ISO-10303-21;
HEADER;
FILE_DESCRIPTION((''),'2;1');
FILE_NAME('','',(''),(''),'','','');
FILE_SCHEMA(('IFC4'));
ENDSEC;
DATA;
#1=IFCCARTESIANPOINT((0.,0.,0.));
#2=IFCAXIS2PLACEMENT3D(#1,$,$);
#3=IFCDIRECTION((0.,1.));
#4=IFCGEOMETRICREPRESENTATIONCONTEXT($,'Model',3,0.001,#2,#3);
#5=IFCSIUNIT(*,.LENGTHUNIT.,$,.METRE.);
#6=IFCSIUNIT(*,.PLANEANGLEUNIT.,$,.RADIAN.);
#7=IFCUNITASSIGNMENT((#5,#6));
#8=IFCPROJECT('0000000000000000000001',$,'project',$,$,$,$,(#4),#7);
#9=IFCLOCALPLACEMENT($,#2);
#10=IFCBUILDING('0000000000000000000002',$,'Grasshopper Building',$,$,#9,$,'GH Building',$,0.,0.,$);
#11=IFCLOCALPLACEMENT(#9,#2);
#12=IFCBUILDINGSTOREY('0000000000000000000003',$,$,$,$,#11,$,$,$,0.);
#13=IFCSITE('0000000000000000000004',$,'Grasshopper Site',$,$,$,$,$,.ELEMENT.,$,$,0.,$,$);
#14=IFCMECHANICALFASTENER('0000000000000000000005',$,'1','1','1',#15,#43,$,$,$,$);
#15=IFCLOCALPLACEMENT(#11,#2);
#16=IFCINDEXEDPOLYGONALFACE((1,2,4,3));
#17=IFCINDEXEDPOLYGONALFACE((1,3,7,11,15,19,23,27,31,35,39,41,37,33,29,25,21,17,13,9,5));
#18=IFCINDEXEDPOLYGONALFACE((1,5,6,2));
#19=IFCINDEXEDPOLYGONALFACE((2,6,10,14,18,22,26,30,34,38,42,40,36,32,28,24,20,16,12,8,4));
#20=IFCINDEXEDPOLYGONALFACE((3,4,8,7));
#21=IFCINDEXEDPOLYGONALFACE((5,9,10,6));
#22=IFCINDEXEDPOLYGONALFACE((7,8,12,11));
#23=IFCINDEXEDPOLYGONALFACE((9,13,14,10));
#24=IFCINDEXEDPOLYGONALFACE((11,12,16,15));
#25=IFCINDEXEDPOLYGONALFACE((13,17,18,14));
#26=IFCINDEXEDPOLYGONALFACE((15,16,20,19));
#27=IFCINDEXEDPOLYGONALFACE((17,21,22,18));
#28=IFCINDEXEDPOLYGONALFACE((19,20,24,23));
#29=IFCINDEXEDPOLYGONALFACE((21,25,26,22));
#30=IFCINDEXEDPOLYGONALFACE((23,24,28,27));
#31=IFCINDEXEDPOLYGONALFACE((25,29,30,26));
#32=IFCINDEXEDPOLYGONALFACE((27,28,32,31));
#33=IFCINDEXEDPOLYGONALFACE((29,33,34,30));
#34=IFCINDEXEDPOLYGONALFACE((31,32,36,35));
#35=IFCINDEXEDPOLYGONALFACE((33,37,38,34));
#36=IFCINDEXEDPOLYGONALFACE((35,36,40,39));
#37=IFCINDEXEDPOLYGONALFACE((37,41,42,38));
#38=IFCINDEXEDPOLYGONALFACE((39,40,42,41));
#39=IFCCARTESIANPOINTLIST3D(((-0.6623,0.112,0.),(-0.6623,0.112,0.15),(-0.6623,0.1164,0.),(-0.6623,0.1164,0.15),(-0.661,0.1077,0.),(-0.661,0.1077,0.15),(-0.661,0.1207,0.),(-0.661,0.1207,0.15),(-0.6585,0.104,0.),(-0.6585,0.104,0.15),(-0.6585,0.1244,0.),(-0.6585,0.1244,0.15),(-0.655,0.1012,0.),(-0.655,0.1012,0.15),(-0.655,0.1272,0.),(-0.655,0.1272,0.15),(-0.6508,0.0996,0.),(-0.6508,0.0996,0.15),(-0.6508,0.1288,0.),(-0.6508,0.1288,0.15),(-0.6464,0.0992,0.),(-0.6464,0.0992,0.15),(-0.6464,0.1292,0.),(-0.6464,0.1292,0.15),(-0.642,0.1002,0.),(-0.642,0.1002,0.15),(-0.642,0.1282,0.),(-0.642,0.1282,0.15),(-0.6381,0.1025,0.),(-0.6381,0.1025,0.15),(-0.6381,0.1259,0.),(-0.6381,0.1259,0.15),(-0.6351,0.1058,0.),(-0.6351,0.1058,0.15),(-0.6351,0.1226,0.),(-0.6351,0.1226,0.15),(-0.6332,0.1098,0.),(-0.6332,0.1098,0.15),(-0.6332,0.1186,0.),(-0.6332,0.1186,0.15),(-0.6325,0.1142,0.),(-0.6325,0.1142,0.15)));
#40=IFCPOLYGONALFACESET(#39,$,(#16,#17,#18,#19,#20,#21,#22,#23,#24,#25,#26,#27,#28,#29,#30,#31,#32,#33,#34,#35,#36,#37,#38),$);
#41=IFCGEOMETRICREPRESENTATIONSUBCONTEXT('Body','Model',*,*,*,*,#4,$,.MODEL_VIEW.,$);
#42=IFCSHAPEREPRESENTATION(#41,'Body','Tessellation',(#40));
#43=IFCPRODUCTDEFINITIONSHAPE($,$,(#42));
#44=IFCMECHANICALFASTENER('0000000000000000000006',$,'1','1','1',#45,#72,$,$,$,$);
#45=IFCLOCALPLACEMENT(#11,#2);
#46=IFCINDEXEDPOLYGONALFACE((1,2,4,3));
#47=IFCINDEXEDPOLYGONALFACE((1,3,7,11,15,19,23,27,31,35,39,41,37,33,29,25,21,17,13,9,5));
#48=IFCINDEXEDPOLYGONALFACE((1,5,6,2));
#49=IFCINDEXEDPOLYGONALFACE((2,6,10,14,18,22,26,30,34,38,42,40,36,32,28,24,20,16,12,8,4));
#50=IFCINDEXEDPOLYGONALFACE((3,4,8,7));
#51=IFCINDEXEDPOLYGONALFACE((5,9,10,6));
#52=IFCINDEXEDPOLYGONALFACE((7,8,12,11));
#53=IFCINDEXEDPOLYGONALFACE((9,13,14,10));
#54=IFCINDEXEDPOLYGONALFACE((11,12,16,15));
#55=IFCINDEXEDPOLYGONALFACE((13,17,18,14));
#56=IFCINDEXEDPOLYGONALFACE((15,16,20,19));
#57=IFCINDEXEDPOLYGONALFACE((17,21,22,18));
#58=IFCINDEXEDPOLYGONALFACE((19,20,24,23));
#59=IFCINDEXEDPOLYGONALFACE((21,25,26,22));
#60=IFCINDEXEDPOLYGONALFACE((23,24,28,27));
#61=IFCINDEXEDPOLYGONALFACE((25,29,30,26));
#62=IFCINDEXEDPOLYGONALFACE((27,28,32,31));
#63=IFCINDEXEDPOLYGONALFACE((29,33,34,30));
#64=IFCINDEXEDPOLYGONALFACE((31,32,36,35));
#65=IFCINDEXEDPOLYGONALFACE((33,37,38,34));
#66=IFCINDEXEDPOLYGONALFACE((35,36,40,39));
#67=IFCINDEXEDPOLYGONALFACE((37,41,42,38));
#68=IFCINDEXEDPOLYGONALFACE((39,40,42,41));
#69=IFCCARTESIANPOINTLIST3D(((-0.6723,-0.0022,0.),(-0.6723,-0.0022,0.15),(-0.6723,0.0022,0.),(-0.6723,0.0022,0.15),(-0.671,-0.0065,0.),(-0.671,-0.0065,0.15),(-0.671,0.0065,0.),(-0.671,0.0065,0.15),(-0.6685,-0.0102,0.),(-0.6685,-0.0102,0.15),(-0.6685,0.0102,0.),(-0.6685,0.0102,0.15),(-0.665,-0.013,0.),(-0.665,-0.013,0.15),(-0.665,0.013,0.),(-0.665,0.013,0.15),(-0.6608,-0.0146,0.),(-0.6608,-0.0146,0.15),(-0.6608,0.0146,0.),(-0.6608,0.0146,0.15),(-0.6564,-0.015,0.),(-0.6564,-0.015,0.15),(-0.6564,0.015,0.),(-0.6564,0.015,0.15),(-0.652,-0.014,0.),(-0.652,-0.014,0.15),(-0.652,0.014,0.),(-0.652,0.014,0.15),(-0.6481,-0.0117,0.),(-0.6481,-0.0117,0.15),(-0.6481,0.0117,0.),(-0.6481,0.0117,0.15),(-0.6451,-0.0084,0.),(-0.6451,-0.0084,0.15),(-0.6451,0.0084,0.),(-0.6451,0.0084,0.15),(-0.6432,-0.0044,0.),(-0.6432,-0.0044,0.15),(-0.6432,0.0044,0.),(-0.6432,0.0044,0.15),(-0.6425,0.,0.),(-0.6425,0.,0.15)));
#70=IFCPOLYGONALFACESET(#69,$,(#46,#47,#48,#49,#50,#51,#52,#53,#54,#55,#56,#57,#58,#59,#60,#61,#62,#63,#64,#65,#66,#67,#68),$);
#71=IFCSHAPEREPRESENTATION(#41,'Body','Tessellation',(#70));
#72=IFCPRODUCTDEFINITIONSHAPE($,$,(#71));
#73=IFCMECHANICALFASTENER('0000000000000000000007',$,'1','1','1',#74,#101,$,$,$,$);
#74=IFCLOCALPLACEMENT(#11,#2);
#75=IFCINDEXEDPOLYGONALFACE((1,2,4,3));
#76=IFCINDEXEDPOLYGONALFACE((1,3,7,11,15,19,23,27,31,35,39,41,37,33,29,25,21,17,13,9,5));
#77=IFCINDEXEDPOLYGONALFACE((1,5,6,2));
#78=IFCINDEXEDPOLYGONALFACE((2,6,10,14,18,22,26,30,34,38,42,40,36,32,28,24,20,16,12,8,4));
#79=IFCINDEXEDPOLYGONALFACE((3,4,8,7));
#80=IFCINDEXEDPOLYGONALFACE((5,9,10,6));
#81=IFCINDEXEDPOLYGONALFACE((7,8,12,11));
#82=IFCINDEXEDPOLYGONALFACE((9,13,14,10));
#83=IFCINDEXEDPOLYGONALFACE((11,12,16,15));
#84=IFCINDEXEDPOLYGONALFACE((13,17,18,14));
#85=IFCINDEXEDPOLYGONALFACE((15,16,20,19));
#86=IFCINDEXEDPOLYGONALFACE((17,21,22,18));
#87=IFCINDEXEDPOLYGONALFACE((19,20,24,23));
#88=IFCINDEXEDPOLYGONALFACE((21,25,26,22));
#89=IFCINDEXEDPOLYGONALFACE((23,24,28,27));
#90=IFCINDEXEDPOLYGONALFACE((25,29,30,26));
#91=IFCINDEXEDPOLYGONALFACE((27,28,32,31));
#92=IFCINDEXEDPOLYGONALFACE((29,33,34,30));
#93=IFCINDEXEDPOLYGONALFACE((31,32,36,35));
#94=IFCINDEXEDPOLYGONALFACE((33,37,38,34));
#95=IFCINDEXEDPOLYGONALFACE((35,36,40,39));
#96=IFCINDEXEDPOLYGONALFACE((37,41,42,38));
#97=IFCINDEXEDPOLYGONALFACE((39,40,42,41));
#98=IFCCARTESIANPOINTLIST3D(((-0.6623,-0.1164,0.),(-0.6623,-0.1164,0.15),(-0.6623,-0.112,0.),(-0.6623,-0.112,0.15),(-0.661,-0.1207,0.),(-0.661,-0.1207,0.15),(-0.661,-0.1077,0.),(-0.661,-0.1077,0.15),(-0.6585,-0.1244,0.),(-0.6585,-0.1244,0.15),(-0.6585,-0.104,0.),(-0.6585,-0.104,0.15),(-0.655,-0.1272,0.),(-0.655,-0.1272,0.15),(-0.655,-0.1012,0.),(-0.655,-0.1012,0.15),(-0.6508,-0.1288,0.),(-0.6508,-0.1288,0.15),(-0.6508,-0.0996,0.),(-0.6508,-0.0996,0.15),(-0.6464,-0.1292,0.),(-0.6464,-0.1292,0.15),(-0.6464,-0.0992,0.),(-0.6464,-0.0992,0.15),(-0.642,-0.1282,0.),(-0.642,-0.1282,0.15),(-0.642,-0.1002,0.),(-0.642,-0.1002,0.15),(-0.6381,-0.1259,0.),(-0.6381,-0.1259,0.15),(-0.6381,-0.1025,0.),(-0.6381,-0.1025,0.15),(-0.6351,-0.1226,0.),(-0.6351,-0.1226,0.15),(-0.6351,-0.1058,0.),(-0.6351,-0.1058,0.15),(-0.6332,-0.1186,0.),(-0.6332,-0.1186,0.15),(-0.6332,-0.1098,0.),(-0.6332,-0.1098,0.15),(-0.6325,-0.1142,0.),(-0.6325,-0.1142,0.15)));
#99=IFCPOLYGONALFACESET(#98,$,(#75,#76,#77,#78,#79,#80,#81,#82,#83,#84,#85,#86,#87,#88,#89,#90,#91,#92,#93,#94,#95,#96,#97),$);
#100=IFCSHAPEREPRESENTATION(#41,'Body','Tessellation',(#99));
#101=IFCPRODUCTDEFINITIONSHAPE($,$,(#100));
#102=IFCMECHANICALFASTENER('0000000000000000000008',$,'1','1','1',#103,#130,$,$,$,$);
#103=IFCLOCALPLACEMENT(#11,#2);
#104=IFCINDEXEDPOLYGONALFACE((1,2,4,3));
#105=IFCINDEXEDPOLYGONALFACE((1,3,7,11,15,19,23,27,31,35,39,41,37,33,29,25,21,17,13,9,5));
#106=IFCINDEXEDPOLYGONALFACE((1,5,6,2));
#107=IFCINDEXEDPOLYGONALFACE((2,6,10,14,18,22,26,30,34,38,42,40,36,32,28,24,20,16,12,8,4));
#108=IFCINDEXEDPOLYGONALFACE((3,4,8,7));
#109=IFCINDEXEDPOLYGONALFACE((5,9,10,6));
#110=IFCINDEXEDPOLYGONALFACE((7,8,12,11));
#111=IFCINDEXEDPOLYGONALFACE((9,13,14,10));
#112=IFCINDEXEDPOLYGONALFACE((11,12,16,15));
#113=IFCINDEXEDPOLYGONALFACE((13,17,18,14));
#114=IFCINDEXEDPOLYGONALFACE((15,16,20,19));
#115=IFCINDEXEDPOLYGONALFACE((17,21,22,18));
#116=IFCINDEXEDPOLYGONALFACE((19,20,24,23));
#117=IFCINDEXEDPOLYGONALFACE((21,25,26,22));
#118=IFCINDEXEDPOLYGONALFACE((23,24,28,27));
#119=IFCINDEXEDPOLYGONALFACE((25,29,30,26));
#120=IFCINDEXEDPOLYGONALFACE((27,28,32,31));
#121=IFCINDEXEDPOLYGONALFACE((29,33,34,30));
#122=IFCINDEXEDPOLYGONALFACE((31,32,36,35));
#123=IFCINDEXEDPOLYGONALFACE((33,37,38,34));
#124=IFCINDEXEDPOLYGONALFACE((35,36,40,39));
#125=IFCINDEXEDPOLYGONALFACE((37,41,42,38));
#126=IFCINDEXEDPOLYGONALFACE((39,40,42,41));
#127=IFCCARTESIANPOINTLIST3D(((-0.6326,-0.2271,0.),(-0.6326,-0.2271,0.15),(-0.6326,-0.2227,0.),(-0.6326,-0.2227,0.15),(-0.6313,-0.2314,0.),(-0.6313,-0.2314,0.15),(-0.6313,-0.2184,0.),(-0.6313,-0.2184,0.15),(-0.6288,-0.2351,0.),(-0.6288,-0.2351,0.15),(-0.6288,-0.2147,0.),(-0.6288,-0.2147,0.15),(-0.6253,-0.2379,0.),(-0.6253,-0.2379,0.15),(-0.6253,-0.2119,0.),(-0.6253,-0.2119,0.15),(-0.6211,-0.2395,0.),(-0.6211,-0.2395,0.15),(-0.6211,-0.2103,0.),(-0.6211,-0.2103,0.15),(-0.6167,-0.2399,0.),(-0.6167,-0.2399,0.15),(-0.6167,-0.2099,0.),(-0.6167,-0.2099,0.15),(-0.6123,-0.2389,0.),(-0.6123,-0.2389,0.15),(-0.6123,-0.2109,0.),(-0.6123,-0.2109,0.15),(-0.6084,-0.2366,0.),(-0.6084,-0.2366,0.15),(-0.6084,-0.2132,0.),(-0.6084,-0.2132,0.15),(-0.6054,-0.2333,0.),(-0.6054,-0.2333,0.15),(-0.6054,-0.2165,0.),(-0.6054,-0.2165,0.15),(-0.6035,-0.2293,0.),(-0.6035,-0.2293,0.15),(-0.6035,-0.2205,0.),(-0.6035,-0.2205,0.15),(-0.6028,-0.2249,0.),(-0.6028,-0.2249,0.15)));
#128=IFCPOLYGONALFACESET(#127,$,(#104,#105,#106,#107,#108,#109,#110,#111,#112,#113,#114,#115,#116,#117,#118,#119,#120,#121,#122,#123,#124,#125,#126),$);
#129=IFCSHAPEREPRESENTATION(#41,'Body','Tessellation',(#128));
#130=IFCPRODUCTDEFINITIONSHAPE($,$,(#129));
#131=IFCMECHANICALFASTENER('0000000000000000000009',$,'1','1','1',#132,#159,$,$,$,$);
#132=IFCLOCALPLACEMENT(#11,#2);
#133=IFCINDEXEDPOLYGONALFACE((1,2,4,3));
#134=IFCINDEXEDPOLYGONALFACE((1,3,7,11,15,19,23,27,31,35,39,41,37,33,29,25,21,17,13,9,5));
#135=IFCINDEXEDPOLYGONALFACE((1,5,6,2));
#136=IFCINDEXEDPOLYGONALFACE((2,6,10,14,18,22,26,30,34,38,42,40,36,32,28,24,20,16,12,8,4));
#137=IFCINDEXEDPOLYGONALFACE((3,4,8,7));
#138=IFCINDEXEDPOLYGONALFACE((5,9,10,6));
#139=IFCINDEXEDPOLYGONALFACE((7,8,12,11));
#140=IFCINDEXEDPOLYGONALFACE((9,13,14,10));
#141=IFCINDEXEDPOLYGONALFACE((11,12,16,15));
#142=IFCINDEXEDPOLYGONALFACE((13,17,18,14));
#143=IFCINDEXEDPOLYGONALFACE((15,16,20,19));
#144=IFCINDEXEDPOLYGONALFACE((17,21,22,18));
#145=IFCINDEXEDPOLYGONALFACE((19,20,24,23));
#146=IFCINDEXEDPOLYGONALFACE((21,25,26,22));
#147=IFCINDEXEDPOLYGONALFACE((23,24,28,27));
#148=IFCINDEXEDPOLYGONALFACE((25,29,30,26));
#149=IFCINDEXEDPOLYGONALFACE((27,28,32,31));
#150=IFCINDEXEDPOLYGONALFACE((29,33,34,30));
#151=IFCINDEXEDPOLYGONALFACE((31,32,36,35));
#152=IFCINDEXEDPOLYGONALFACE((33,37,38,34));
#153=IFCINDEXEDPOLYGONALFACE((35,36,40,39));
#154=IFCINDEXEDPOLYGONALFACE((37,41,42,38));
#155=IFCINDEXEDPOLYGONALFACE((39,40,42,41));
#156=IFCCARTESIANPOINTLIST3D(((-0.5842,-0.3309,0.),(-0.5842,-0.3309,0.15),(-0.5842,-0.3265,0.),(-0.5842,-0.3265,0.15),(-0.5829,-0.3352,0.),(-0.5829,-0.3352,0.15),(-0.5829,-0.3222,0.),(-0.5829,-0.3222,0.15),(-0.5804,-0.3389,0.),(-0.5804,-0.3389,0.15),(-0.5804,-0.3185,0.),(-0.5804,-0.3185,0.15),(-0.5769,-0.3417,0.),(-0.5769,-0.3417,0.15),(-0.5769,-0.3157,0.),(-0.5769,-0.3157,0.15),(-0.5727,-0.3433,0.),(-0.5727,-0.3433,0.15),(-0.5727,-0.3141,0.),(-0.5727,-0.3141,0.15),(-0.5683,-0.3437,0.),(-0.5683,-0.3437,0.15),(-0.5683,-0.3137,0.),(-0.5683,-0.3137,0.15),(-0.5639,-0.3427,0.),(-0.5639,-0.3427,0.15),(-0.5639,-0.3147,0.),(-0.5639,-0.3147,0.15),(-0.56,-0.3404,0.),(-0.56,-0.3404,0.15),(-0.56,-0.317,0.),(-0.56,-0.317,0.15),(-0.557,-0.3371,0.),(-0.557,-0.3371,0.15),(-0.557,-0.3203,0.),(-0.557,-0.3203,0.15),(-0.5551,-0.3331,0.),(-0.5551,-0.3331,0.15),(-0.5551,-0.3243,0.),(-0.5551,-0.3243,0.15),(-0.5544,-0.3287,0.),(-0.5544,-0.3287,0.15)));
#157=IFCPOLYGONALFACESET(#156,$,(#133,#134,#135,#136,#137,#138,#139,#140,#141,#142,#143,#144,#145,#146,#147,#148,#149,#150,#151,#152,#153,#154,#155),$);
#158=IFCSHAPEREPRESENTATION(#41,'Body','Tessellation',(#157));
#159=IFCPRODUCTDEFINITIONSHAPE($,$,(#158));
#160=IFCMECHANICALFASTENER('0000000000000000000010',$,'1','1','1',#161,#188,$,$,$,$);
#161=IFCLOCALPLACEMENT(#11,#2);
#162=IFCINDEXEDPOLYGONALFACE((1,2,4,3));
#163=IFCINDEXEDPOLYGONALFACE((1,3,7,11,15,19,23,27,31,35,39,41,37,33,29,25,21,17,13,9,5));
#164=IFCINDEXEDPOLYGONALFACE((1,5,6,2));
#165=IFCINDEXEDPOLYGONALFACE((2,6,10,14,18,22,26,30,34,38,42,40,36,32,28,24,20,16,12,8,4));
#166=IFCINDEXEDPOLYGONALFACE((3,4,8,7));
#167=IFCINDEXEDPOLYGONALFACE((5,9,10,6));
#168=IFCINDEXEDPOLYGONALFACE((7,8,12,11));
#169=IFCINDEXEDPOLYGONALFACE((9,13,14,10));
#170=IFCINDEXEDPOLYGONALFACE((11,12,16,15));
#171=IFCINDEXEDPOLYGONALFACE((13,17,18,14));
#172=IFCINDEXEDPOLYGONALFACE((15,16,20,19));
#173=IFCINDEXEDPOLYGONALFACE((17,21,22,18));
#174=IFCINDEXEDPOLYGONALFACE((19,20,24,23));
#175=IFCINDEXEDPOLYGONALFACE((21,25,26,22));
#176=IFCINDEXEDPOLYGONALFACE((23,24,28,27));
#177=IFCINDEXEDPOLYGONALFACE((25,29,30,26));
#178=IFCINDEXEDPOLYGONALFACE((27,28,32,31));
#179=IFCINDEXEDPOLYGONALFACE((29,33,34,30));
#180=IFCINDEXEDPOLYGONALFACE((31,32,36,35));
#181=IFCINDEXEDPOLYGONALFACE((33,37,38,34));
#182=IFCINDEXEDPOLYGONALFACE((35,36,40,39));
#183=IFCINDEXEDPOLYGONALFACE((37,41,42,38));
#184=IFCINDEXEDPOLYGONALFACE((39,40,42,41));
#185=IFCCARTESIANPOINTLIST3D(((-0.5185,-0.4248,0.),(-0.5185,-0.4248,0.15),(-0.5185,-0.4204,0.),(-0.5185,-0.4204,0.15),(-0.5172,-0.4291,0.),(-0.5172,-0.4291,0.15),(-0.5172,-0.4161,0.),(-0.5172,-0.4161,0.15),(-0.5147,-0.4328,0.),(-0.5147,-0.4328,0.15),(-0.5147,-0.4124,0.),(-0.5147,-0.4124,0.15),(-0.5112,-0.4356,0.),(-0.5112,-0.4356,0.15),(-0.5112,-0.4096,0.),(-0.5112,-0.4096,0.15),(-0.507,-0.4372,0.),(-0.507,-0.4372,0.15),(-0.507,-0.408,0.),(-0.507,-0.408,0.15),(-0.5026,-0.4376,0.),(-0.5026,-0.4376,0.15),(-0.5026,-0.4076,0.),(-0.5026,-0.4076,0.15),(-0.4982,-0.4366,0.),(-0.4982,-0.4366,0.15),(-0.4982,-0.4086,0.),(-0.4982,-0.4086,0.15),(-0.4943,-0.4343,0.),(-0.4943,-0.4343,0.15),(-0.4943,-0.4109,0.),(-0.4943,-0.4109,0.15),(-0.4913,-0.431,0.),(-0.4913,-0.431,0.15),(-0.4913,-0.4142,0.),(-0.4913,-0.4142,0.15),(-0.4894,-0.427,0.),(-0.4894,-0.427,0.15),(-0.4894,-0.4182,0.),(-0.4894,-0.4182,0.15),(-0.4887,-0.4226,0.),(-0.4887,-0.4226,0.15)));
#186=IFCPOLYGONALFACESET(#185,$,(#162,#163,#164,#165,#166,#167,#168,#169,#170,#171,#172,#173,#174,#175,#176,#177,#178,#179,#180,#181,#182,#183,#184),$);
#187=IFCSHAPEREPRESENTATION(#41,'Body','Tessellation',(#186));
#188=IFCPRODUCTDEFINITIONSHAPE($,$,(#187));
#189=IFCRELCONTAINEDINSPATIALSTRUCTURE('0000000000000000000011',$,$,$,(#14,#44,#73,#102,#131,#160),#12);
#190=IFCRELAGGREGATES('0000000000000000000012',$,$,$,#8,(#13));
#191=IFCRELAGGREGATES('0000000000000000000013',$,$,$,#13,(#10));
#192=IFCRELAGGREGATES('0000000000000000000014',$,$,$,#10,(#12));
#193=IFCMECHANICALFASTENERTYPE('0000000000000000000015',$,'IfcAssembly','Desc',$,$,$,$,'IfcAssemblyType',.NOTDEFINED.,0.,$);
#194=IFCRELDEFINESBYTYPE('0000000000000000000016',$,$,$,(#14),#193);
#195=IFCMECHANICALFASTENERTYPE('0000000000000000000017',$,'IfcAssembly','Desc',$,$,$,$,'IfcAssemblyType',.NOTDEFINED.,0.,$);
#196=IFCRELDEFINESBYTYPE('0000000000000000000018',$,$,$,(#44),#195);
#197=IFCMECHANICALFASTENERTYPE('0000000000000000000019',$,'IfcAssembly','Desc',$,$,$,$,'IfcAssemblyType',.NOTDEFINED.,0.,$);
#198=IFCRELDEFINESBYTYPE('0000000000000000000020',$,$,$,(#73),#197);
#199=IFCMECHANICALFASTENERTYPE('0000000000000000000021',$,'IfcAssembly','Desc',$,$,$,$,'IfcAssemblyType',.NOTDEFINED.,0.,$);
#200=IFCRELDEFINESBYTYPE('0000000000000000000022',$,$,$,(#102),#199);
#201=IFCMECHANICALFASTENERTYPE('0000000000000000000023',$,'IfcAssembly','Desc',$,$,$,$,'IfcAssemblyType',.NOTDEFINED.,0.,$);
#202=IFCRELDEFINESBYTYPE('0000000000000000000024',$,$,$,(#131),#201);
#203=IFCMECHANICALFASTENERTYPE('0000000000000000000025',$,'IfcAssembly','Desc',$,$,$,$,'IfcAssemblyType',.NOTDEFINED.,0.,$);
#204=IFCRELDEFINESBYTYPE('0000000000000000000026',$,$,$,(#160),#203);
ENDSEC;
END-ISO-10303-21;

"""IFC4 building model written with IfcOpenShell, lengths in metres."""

from ifc_helpers import new_model, si_unit, direction, frame, origin, place, context, subcontext, project, spatial, circle, extrude, source, transform, mapped, type_object, type_shapes, element, save


model = new_model("IFC4")

# Units and contexts
model_context = context("Model", 3, precision=0.001, world=origin(), true_north=direction((0.0, 1.0)))
body_context = subcontext(model_context, "Body", "Model", "MODEL_VIEW")
ifc_project = project(units=[si_unit("LENGTHUNIT", "METRE"), si_unit("PLANEANGLEUNIT", "RADIAN")], contexts=[model_context])

# Site, building, storey
site = spatial("IfcSite", under=ifc_project, Name="Grasshopper Site", CompositionType="ELEMENT", RefElevation=0.0)
building_placement = place(None, origin())
building = spatial("IfcBuilding", under=site, at=building_placement, Name="Grasshopper Building", LongName="GH Building", ElevationOfRefHeight=0.0, ElevationOfTerrain=0.0)
storey_placement = place(building_placement, origin())
storey = spatial("IfcBuildingStorey", under=building, at=storey_placement, Elevation=0.0)

# Mechanical fasteners
mechanical_fastener_type_1 = type_object("IfcMechanicalFastenerType", Name="IfcAssembly", Description="Desc", ElementType="IfcAssemblyType", NominalDiameter=0.0)
shared_shape_1 = source(origin(), body_context, "Body", "SweptSolid", [
    extrude(circle(Radius=0.015), frame((-0.6475, 0.1142, 0.0)), (0.0, 0.0, 1.0), 0.15),
])
type_shapes(mechanical_fastener_type_1, [shared_shape_1])
mechanical_fastener_1_placement = place(storey_placement, origin())
element("IfcMechanicalFastener", 1, at=mechanical_fastener_1_placement, inside=storey, type_object=mechanical_fastener_type_1, Name="1", Description="1", ObjectType="1", context=body_context, shape_type="MappedRepresentation", body=[
    mapped(shared_shape_1, transform((0.0, 0.0, 0.0), scale=1.0)),
])
mechanical_fastener_type_2 = type_object("IfcMechanicalFastenerType", Name="IfcAssembly", Description="Desc", ElementType="IfcAssemblyType", NominalDiameter=0.0)
shared_shape_2 = source(origin(), body_context, "Body", "SweptSolid", [
    extrude(circle(Radius=0.015), frame((-0.6575, 0.0, 0.0)), (0.0, 0.0, 1.0), 0.15),
])
type_shapes(mechanical_fastener_type_2, [shared_shape_2])
mechanical_fastener_2_placement = place(storey_placement, origin())
element("IfcMechanicalFastener", 2, at=mechanical_fastener_2_placement, inside=storey, type_object=mechanical_fastener_type_2, Name="1", Description="1", ObjectType="1", context=body_context, shape_type="MappedRepresentation", body=[
    mapped(shared_shape_2, transform((0.0, 0.0, 0.0), scale=1.0)),
])
mechanical_fastener_type_3 = type_object("IfcMechanicalFastenerType", Name="IfcAssembly", Description="Desc", ElementType="IfcAssemblyType", NominalDiameter=0.0)
shared_shape_3 = source(origin(), body_context, "Body", "SweptSolid", [
    extrude(circle(Radius=0.015), frame((-0.6475, -0.1142, 0.0)), (0.0, 0.0, 1.0), 0.15),
])
type_shapes(mechanical_fastener_type_3, [shared_shape_3])
mechanical_fastener_3_placement = place(storey_placement, origin())
element("IfcMechanicalFastener", 3, at=mechanical_fastener_3_placement, inside=storey, type_object=mechanical_fastener_type_3, Name="1", Description="1", ObjectType="1", context=body_context, shape_type="MappedRepresentation", body=[
    mapped(shared_shape_3, transform((0.0, 0.0, 0.0), scale=1.0)),
])
mechanical_fastener_type_4 = type_object("IfcMechanicalFastenerType", Name="IfcAssembly", Description="Desc", ElementType="IfcAssemblyType", NominalDiameter=0.0)
shared_shape_4 = source(origin(), body_context, "Body", "SweptSolid", [
    extrude(circle(Radius=0.015), frame((-0.6178, -0.2249, 0.0)), (0.0, 0.0, 1.0), 0.15),
])
type_shapes(mechanical_fastener_type_4, [shared_shape_4])
mechanical_fastener_4_placement = place(storey_placement, origin())
element("IfcMechanicalFastener", 4, at=mechanical_fastener_4_placement, inside=storey, type_object=mechanical_fastener_type_4, Name="1", Description="1", ObjectType="1", context=body_context, shape_type="MappedRepresentation", body=[
    mapped(shared_shape_4, transform((0.0, 0.0, 0.0), scale=1.0)),
])
mechanical_fastener_type_5 = type_object("IfcMechanicalFastenerType", Name="IfcAssembly", Description="Desc", ElementType="IfcAssemblyType", NominalDiameter=0.0)
shared_shape_5 = source(origin(), body_context, "Body", "SweptSolid", [
    extrude(circle(Radius=0.015), frame((-0.5694, -0.3287, 0.0)), (0.0, 0.0, 1.0), 0.15),
])
type_shapes(mechanical_fastener_type_5, [shared_shape_5])
mechanical_fastener_5_placement = place(storey_placement, origin())
element("IfcMechanicalFastener", 5, at=mechanical_fastener_5_placement, inside=storey, type_object=mechanical_fastener_type_5, Name="1", Description="1", ObjectType="1", context=body_context, shape_type="MappedRepresentation", body=[
    mapped(shared_shape_5, transform((0.0, 0.0, 0.0), scale=1.0)),
])
mechanical_fastener_type_6 = type_object("IfcMechanicalFastenerType", Name="IfcAssembly", Description="Desc", ElementType="IfcAssemblyType", NominalDiameter=0.0)
shared_shape_6 = source(origin(), body_context, "Body", "SweptSolid", [
    extrude(circle(Radius=0.015), frame((-0.5037, -0.4226, 0.0)), (0.0, 0.0, 1.0), 0.15),
])
type_shapes(mechanical_fastener_type_6, [shared_shape_6])
mechanical_fastener_6_placement = place(storey_placement, origin())
element("IfcMechanicalFastener", 6, at=mechanical_fastener_6_placement, inside=storey, type_object=mechanical_fastener_type_6, Name="1", Description="1", ObjectType="1", context=body_context, shape_type="MappedRepresentation", body=[
    mapped(shared_shape_6, transform((0.0, 0.0, 0.0), scale=1.0)),
])

save(model, "model.ifc")
